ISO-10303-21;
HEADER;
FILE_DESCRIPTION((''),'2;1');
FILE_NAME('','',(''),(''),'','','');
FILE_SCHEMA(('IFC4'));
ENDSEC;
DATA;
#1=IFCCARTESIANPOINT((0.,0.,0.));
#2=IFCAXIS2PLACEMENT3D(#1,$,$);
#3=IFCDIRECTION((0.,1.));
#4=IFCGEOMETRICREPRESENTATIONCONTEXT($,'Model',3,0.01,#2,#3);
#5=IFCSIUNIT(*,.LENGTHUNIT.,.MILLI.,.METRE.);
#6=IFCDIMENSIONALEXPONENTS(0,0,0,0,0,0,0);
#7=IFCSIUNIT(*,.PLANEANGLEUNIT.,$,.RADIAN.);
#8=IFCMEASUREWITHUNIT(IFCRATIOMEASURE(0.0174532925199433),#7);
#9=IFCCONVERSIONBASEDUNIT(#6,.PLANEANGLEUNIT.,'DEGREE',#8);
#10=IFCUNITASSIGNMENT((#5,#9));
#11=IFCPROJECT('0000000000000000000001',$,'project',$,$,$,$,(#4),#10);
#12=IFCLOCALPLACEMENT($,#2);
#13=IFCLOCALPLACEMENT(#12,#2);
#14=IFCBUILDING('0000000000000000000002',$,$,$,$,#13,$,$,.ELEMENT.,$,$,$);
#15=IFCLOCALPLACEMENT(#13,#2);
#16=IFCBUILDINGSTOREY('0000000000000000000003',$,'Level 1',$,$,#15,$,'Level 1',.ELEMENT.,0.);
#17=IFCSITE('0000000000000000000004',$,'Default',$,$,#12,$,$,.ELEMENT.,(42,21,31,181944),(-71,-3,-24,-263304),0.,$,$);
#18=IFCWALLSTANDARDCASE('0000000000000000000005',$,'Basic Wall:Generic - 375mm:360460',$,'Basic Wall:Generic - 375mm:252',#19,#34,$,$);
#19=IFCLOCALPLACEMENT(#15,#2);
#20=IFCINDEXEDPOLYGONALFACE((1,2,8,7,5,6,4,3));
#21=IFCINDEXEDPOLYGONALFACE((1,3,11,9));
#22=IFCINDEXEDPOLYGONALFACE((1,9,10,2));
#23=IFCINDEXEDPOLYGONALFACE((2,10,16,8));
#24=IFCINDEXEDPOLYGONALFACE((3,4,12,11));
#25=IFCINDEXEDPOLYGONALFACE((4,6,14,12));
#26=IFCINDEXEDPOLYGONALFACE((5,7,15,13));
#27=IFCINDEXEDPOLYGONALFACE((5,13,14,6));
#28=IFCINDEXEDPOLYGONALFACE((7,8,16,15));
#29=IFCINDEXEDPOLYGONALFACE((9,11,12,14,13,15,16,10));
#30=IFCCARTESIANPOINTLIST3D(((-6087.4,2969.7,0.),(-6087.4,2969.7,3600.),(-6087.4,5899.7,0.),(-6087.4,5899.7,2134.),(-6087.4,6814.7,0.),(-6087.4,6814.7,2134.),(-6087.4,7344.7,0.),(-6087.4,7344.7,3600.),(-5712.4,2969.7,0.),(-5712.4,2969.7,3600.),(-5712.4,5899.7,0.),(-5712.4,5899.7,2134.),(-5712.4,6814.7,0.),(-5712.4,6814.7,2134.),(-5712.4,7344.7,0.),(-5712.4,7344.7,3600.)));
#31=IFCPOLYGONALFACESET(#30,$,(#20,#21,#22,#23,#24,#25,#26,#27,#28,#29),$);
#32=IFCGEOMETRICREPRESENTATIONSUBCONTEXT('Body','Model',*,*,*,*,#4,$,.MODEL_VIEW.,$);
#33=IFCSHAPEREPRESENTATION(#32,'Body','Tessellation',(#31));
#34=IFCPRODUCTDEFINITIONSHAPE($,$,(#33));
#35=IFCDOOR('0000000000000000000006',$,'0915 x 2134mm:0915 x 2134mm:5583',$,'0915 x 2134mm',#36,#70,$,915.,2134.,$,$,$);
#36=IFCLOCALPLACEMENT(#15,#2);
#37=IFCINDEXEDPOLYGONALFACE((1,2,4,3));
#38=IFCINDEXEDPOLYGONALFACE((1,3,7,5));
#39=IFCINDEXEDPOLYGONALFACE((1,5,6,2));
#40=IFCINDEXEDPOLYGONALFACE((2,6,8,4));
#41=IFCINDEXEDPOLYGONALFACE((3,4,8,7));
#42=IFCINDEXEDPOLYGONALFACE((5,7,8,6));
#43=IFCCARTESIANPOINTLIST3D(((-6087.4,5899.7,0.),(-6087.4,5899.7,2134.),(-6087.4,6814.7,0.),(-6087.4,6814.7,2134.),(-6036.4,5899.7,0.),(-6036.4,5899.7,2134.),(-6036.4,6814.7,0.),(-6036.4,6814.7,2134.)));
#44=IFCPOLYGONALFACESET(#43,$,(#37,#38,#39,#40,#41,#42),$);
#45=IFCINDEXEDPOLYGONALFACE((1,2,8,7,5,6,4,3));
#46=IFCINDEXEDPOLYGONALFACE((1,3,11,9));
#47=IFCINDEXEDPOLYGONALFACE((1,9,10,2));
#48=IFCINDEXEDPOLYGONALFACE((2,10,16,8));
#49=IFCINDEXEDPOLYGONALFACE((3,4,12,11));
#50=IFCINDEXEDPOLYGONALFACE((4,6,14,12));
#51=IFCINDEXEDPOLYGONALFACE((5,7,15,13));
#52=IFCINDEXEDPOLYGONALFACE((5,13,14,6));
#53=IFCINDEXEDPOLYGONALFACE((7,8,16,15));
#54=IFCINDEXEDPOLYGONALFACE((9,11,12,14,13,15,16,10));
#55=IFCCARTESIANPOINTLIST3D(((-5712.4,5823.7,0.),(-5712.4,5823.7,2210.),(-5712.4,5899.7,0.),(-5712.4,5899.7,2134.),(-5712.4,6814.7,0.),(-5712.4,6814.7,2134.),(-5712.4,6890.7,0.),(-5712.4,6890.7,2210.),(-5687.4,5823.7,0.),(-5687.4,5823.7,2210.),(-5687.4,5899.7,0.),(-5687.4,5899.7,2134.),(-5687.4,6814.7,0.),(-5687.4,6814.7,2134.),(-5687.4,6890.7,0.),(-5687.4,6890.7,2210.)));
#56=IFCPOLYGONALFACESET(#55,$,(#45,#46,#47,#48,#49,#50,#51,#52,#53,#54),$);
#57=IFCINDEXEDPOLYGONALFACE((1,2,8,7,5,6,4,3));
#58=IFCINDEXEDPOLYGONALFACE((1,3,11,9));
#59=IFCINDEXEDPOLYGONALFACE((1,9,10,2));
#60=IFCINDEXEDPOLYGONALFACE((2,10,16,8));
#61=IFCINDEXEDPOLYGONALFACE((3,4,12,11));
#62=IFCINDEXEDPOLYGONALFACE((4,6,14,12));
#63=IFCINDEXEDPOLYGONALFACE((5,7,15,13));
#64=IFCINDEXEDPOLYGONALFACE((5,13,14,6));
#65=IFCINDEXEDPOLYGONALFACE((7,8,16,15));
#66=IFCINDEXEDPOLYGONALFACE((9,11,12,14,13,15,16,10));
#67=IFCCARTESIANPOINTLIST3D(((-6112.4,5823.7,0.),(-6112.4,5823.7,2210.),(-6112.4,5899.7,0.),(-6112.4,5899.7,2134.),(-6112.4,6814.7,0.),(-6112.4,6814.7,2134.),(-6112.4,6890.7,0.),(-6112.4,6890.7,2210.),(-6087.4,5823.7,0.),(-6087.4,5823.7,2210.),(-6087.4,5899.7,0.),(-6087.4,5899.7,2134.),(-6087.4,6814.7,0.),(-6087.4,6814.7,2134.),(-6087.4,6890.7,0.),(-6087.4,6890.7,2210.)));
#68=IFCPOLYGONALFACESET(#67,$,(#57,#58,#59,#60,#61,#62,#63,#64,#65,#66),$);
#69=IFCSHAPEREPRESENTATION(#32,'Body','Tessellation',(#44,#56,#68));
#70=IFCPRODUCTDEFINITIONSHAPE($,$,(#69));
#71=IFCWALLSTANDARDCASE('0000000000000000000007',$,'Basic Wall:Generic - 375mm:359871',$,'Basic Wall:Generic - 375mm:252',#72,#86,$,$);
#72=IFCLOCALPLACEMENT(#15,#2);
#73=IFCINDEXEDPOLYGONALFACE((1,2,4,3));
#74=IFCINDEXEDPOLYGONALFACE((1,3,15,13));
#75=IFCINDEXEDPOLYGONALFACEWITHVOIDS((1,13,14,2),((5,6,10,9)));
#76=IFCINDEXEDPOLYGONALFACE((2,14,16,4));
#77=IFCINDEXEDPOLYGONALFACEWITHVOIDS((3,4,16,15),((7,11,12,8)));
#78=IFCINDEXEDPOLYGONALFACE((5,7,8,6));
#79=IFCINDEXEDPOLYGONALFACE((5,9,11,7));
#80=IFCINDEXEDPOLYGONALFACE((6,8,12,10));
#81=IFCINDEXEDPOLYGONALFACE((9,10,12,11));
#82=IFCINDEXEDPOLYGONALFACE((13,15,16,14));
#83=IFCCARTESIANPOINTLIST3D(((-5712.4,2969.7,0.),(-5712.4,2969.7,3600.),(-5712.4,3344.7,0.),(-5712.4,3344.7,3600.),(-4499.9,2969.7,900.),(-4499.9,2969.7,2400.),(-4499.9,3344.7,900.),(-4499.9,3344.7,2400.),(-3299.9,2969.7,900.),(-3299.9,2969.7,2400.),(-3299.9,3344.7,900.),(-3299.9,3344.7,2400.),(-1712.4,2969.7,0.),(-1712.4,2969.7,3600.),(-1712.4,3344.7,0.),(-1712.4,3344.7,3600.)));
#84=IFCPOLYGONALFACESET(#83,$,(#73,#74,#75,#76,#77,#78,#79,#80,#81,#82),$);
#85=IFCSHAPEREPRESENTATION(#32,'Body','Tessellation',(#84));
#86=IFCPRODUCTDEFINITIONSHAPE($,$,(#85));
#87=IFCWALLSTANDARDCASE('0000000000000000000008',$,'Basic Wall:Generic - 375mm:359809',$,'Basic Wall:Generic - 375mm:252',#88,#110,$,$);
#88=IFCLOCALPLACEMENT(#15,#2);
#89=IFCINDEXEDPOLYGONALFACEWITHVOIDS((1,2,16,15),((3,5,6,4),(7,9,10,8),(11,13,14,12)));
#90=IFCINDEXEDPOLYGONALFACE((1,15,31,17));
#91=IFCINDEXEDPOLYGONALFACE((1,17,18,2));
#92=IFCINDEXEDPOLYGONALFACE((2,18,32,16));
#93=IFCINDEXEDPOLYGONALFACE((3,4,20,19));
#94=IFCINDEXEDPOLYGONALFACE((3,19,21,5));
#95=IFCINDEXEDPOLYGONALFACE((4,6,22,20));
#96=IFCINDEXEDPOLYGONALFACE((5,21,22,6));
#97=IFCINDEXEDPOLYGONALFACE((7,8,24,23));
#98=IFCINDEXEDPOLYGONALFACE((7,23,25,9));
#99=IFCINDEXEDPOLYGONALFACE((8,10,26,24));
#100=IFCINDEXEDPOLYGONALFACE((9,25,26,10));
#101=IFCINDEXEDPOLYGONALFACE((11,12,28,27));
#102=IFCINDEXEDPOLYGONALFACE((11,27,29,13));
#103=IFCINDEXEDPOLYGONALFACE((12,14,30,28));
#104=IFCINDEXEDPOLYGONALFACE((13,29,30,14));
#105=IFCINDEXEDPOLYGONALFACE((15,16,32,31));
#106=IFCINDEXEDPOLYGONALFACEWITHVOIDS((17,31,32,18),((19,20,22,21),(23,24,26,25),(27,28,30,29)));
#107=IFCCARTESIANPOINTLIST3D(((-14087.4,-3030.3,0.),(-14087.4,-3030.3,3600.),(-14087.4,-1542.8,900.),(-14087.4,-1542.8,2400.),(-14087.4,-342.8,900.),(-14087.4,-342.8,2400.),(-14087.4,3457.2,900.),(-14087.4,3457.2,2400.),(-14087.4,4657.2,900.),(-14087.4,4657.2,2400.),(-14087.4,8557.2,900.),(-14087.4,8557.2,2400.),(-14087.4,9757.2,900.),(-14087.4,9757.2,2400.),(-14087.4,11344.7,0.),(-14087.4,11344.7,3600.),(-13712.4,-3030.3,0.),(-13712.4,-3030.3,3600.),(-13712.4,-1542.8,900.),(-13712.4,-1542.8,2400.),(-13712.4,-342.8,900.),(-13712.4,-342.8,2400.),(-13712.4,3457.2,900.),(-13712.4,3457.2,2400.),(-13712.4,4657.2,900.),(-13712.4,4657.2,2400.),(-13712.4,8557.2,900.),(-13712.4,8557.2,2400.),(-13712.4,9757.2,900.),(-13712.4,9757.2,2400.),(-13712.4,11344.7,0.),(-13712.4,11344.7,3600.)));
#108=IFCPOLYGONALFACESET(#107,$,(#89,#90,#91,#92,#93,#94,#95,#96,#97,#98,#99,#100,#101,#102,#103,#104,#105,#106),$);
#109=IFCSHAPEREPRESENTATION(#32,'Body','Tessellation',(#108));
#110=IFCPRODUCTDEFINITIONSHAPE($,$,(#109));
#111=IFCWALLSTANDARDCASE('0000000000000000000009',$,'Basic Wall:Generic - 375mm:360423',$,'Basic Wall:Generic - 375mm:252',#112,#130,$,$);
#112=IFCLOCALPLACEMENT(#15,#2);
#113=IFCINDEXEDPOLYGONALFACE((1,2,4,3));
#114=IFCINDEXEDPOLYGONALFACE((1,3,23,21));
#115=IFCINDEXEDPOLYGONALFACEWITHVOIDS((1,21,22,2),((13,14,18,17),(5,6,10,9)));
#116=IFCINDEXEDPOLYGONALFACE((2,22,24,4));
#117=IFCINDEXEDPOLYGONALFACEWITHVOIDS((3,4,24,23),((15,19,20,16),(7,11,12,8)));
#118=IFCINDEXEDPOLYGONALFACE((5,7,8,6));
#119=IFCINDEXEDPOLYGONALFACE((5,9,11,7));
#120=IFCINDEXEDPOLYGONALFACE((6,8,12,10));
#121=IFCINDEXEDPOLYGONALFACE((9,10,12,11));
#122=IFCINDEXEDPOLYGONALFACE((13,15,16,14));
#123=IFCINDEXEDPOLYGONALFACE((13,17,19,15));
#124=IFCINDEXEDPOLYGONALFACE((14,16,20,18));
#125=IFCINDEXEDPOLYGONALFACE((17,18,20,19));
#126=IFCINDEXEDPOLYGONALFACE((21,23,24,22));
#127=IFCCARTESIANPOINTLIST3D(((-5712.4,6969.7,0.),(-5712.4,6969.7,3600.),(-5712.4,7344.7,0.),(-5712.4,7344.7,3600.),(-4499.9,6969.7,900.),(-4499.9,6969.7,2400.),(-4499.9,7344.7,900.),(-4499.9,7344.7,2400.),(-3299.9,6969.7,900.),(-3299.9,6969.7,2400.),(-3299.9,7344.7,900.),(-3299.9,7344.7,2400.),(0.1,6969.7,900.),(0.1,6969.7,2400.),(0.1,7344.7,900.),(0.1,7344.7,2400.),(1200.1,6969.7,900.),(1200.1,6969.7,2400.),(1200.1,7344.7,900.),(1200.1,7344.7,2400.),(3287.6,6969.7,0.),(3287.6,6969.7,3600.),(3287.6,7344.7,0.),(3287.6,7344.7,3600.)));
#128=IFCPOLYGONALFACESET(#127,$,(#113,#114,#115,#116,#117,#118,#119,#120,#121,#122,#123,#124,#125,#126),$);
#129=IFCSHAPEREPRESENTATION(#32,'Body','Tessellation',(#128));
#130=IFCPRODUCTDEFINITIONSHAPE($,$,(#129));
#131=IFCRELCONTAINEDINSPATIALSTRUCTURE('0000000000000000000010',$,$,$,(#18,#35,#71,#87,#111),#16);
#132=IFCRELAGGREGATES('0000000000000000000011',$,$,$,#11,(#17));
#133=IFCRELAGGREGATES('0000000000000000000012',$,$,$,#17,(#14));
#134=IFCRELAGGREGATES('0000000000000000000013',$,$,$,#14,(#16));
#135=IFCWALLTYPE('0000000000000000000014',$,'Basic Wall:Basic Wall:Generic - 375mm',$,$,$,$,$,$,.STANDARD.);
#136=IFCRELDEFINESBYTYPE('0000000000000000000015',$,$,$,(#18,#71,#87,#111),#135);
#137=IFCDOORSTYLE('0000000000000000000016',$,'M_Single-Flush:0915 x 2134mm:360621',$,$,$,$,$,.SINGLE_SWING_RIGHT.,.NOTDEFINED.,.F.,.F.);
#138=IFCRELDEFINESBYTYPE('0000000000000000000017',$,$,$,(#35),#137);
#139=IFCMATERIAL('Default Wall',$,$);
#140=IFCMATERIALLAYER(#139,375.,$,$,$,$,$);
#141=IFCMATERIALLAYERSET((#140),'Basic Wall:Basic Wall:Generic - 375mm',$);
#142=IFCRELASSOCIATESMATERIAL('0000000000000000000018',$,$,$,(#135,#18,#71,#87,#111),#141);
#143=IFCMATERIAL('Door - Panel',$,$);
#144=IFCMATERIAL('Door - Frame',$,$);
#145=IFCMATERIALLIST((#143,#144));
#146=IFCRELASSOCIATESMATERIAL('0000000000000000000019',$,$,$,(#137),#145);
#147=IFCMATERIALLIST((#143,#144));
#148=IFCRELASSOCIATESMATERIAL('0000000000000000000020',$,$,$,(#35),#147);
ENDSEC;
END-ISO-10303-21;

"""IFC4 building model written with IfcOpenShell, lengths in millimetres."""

from ifc_helpers import new_model, entity, si_unit, converted_unit, direction, frame, frame_2d, origin, origin_2d_with_axis, place, context, subcontext, project, spatial, polyline, rectangle, outline, extrude, source, transform, mapped, material, material_list, layer, layer_set, layer_usage, type_object, type_shapes, element, fill, save


model = new_model("IFC4")

# Units and contexts
model_context = context("Model", 3, precision=0.01, world=origin(), true_north=direction((0.0, 1.0)))
body_context = subcontext(model_context, "Body", "Model", "MODEL_VIEW")
ifc_project = project(units=[si_unit("LENGTHUNIT", "METRE", prefix="MILLI"), converted_unit("PLANEANGLEUNIT", "DEGREE", entity("IfcRatioMeasure", 0.0174532925199433), si_unit("PLANEANGLEUNIT", "RADIAN"), dimensions=[0, 0, 0, 0, 0, 0, 0])], contexts=[model_context])

# Site, building, storey
site_placement = place(None, origin())
site = spatial("IfcSite", under=ifc_project, at=site_placement, Name="Default", CompositionType="ELEMENT", RefLatitude=(42, 21, 31, 181944), RefLongitude=(-71, -3, -24, -263304), RefElevation=0.0)
building_placement = place(site_placement, origin())
building = spatial("IfcBuilding", under=site, at=building_placement, CompositionType="ELEMENT")
storey_placement = place(building_placement, origin())
storey = spatial("IfcBuildingStorey", under=building, at=storey_placement, Name="Level 1", LongName="Level 1", CompositionType="ELEMENT", Elevation=0.0)

# Wall, opening, door
ifc_material_1 = material(Name="Default Wall")
ifc_layer_1 = layer(ifc_material_1, 375.0)
ifc_layer_set_1 = layer_set([ifc_layer_1], Name="Basic Wall:Basic Wall:Generic - 375mm")
ifc_layer_usage_1 = layer_usage(ifc_layer_set_1, "AXIS2", "NEGATIVE", 187.5)
wall_type_1 = type_object("IfcWallType", Name="Basic Wall:Basic Wall:Generic - 375mm", PredefinedType="STANDARD", material=ifc_layer_set_1)
wall_1_placement = place(storey_placement, frame((-5899.9, 2969.7, 0.0), z_axis=(0.0, 0.0, 1.0), x_axis=(0.0, 1.0, 0.0)))
wall_1 = element("IfcWallStandardCase", 1, at=wall_1_placement, inside=storey, type_object=wall_type_1, material=ifc_layer_usage_1, Name="Basic Wall:Generic - 375mm:360460", ObjectType="Basic Wall:Generic - 375mm:252", context=body_context, shape_type="SweptSolid", body=[
    extrude(rectangle(XDim=4375.0, YDim=375.0, at=frame_2d((2187.5, 0.0), x_axis=(-1.0, 0.0))), origin(), (0.0, 0.0, 1.0), 3600.0),
])
opening_1_placement = place(wall_1_placement, frame((-2969.7, -5899.9, 0.0), z_axis=(0.0, 0.0, 1.0), x_axis=(0.0, -1.0, 0.0)))
opening_1 = element("IfcOpeningElement", 2, at=opening_1_placement, cuts=wall_1, ObjectType="Opening", context=body_context, shape_type="SweptSolid", body=[
    extrude(rectangle(XDim=2134.0, YDim=915.0, at=origin_2d_with_axis()), frame((-5708.7, 6357.2, 1067.0), z_axis=(-1.0, 0.0, 0.0), x_axis=(0.0, 0.0, -1.0)), (0.0, 0.0, 1.0), 382.5),
])
ifc_material_2 = material(Name="Door - Panel")
ifc_material_3 = material(Name="Door - Frame")
ifc_material_list_1 = material_list([ifc_material_2, ifc_material_3])
ifc_material_list_2 = material_list([ifc_material_2, ifc_material_3])
door_style_1 = type_object("IfcDoorStyle", Name="M_Single-Flush:0915 x 2134mm:360621", ConstructionType="NOTDEFINED", OperationType="SINGLE_SWING_RIGHT", ParameterTakesPrecedence=False, Sizeable=False, material=ifc_material_list_2)
shared_shape_1 = source(origin(), body_context, "Body", "SweptSolid", [
    extrude(rectangle(XDim=915.0, YDim=51.0, at=origin_2d_with_axis()), frame((457.5, -29.3, 0.0), z_axis=(0.0, 0.0, 1.0), x_axis=(-1.0, 0.0, 0.0)), (0.0, 0.0, 1.0), 2134.0),
    extrude(outline(polyline([(-533.5, -1086.0), (-457.5, -1086.0), (-457.5, 1048.0), (457.5, 1048.0), (457.5, -1086.0), (533.5, -1086.0), (533.5, 1124.0), (-533.5, 1124.0), (-533.5, -1086.0)])), frame((457.5, -403.7, 1086.0), z_axis=(0.0, 1.0, 0.0), x_axis=(-1.0, 0.0, 0.0)), (0.0, 0.0, 1.0), 25.0),
    extrude(outline(polyline([(-1124.0, -533.5), (1086.0, -533.5), (1086.0, -457.5), (-1048.0, -457.5), (-1048.0, 457.5), (1086.0, 457.5), (1086.0, 533.5), (-1124.0, 533.5), (-1124.0, -533.5)])), frame((457.5, -3.7, 1086.0), z_axis=(0.0, 1.0, 0.0), x_axis=(0.0, 0.0, -1.0)), (0.0, 0.0, 1.0), 25.0),
])
type_shapes(door_style_1, [shared_shape_1])
door_1_placement = place(opening_1_placement, frame((-6091.2, 5899.7, 0.0), z_axis=(0.0, 0.0, 1.0), x_axis=(0.0, 1.0, 0.0)))
door_1 = element("IfcDoor", 3, at=door_1_placement, inside=storey, type_object=door_style_1, material=ifc_material_list_1, Name="0915 x 2134mm:0915 x 2134mm:5583", ObjectType="0915 x 2134mm", OverallHeight=915.0, OverallWidth=2134.0, context=body_context, shape_type="MappedRepresentation", body=[
    mapped(shared_shape_1, transform((0.0, 0.0, 0.0), scale=1.0)),
])
fill(opening_1, door_1)

# Wall, opening
ifc_layer_usage_2 = layer_usage(ifc_layer_set_1, "AXIS2", "NEGATIVE", 187.5)
wall_2_placement = place(storey_placement, frame((-1712.4, 3157.2, 0.0), z_axis=(0.0, 0.0, 1.0), x_axis=(-1.0, 0.0, 0.0)))
wall_2 = element("IfcWallStandardCase", 4, at=wall_2_placement, inside=storey, type_object=wall_type_1, material=ifc_layer_usage_2, Name="Basic Wall:Generic - 375mm:359871", ObjectType="Basic Wall:Generic - 375mm:252", context=body_context, shape_type="SweptSolid", body=[
    extrude(rectangle(XDim=4000.0, YDim=375.0, at=frame_2d((2000.0, 0.0), x_axis=(-1.0, 0.0))), origin(), (0.0, 0.0, 1.0), 3600.0),
])
opening_2_placement = place(wall_2_placement, frame((-1712.4, 3157.2, 0.0), z_axis=(0.0, 0.0, 1.0), x_axis=(-1.0, 0.0, 0.0)))
element("IfcOpeningElement", 5, at=opening_2_placement, cuts=wall_2, ObjectType="Opening", context=body_context, shape_type="SweptSolid", body=[
    extrude(rectangle(XDim=1500.0, YDim=1200.0, at=frame_2d((0.0, 0.0), x_axis=(0.0, 1.0))), frame((-3899.9, 3348.4, 1650.0), z_axis=(0.0, -1.0, 0.0), x_axis=(1.0, 0.0, 0.0)), (0.0, 0.0, 1.0), 382.5),
])

# Walls, openings
ifc_layer_usage_3 = layer_usage(ifc_layer_set_1, "AXIS2", "NEGATIVE", 187.5)
wall_3_placement = place(storey_placement, frame((-13899.9, 11344.7, 0.0), z_axis=(0.0, 0.0, 1.0), x_axis=(0.0, -1.0, 0.0)))
wall_3 = element("IfcWallStandardCase", 6, at=wall_3_placement, inside=storey, type_object=wall_type_1, material=ifc_layer_usage_3, Name="Basic Wall:Generic - 375mm:359809", ObjectType="Basic Wall:Generic - 375mm:252", context=body_context, shape_type="SweptSolid", body=[
    extrude(rectangle(XDim=14375.0, YDim=375.0, at=frame_2d((7187.5, 0.0), x_axis=(-1.0, 0.0))), origin(), (0.0, 0.0, 1.0), 3600.0),
])
opening_3_placement = place(wall_3_placement, frame((11344.7, 13899.9, 0.0), z_axis=(0.0, 0.0, 1.0), x_axis=(0.0, 1.0, 0.0)))
element("IfcOpeningElement", 7, at=opening_3_placement, cuts=wall_3, ObjectType="Opening", context=body_context, shape_type="SweptSolid", body=[
    extrude(rectangle(XDim=1500.0, YDim=1200.0, at=frame_2d((0.0, 0.0), x_axis=(0.0, 1.0))), frame((-14091.2, 9157.2, 1650.0), z_axis=(1.0, 0.0, 0.0), x_axis=(0.0, 1.0, 0.0)), (0.0, 0.0, 1.0), 382.5),
])
opening_4_placement = place(wall_3_placement, frame((11344.7, 13899.9, 0.0), z_axis=(0.0, 0.0, 1.0), x_axis=(0.0, 1.0, 0.0)))
element("IfcOpeningElement", 8, at=opening_4_placement, cuts=wall_3, ObjectType="Opening", context=body_context, shape_type="SweptSolid", body=[
    extrude(rectangle(XDim=1500.0, YDim=1200.0, at=frame_2d((0.0, 0.0), x_axis=(0.0, 1.0))), frame((-14091.2, 4057.2, 1650.0), z_axis=(1.0, 0.0, 0.0), x_axis=(0.0, 1.0, 0.0)), (0.0, 0.0, 1.0), 382.5),
])
opening_5_placement = place(wall_3_placement, frame((11344.7, 13899.9, 0.0), z_axis=(0.0, 0.0, 1.0), x_axis=(0.0, 1.0, 0.0)))
element("IfcOpeningElement", 9, at=opening_5_placement, cuts=wall_3, ObjectType="Opening", context=body_context, shape_type="SweptSolid", body=[
    extrude(rectangle(XDim=1500.0, YDim=1200.0, at=frame_2d((0.0, 0.0), x_axis=(0.0, 1.0))), frame((-14091.2, -942.8, 1650.0), z_axis=(1.0, 0.0, 0.0), x_axis=(0.0, 1.0, 0.0)), (0.0, 0.0, 1.0), 382.5),
])
ifc_layer_usage_4 = layer_usage(ifc_layer_set_1, "AXIS2", "NEGATIVE", 187.5)
wall_4_placement = place(storey_placement, frame((-5712.4, 7157.2, 0.0)))
wall_4 = element("IfcWallStandardCase", 10, at=wall_4_placement, inside=storey, type_object=wall_type_1, material=ifc_layer_usage_4, Name="Basic Wall:Generic - 375mm:360423", ObjectType="Basic Wall:Generic - 375mm:252", context=body_context, shape_type="SweptSolid", body=[
    extrude(rectangle(XDim=9000.0, YDim=375.0, at=frame_2d((4500.0, 0.0), x_axis=(-1.0, 0.0))), origin(), (0.0, 0.0, 1.0), 3600.0),
])
opening_6_placement = place(wall_4_placement, frame((5712.4, -7157.2, 0.0)))
element("IfcOpeningElement", 11, at=opening_6_placement, cuts=wall_4, ObjectType="Opening", context=body_context, shape_type="SweptSolid", body=[
    extrude(rectangle(XDim=1500.0, YDim=1200.0, at=frame_2d((0.0, 0.0), x_axis=(0.0, 1.0))), frame((-3899.9, 6965.9, 1650.0), z_axis=(0.0, 1.0, 0.0), x_axis=(-1.0, 0.0, 0.0)), (0.0, 0.0, 1.0), 382.5),
])
opening_7_placement = place(wall_4_placement, frame((5712.4, -7157.2, 0.0)))
element("IfcOpeningElement", 12, at=opening_7_placement, cuts=wall_4, ObjectType="Opening", context=body_context, shape_type="SweptSolid", body=[
    extrude(rectangle(XDim=1500.0, YDim=1200.0, at=frame_2d((0.0, 0.0), x_axis=(0.0, 1.0))), frame((600.1, 6965.9, 1650.0), z_axis=(0.0, 1.0, 0.0), x_axis=(-1.0, 0.0, 0.0)), (0.0, 0.0, 1.0), 382.5),
])

save(model, "model.ifc")
